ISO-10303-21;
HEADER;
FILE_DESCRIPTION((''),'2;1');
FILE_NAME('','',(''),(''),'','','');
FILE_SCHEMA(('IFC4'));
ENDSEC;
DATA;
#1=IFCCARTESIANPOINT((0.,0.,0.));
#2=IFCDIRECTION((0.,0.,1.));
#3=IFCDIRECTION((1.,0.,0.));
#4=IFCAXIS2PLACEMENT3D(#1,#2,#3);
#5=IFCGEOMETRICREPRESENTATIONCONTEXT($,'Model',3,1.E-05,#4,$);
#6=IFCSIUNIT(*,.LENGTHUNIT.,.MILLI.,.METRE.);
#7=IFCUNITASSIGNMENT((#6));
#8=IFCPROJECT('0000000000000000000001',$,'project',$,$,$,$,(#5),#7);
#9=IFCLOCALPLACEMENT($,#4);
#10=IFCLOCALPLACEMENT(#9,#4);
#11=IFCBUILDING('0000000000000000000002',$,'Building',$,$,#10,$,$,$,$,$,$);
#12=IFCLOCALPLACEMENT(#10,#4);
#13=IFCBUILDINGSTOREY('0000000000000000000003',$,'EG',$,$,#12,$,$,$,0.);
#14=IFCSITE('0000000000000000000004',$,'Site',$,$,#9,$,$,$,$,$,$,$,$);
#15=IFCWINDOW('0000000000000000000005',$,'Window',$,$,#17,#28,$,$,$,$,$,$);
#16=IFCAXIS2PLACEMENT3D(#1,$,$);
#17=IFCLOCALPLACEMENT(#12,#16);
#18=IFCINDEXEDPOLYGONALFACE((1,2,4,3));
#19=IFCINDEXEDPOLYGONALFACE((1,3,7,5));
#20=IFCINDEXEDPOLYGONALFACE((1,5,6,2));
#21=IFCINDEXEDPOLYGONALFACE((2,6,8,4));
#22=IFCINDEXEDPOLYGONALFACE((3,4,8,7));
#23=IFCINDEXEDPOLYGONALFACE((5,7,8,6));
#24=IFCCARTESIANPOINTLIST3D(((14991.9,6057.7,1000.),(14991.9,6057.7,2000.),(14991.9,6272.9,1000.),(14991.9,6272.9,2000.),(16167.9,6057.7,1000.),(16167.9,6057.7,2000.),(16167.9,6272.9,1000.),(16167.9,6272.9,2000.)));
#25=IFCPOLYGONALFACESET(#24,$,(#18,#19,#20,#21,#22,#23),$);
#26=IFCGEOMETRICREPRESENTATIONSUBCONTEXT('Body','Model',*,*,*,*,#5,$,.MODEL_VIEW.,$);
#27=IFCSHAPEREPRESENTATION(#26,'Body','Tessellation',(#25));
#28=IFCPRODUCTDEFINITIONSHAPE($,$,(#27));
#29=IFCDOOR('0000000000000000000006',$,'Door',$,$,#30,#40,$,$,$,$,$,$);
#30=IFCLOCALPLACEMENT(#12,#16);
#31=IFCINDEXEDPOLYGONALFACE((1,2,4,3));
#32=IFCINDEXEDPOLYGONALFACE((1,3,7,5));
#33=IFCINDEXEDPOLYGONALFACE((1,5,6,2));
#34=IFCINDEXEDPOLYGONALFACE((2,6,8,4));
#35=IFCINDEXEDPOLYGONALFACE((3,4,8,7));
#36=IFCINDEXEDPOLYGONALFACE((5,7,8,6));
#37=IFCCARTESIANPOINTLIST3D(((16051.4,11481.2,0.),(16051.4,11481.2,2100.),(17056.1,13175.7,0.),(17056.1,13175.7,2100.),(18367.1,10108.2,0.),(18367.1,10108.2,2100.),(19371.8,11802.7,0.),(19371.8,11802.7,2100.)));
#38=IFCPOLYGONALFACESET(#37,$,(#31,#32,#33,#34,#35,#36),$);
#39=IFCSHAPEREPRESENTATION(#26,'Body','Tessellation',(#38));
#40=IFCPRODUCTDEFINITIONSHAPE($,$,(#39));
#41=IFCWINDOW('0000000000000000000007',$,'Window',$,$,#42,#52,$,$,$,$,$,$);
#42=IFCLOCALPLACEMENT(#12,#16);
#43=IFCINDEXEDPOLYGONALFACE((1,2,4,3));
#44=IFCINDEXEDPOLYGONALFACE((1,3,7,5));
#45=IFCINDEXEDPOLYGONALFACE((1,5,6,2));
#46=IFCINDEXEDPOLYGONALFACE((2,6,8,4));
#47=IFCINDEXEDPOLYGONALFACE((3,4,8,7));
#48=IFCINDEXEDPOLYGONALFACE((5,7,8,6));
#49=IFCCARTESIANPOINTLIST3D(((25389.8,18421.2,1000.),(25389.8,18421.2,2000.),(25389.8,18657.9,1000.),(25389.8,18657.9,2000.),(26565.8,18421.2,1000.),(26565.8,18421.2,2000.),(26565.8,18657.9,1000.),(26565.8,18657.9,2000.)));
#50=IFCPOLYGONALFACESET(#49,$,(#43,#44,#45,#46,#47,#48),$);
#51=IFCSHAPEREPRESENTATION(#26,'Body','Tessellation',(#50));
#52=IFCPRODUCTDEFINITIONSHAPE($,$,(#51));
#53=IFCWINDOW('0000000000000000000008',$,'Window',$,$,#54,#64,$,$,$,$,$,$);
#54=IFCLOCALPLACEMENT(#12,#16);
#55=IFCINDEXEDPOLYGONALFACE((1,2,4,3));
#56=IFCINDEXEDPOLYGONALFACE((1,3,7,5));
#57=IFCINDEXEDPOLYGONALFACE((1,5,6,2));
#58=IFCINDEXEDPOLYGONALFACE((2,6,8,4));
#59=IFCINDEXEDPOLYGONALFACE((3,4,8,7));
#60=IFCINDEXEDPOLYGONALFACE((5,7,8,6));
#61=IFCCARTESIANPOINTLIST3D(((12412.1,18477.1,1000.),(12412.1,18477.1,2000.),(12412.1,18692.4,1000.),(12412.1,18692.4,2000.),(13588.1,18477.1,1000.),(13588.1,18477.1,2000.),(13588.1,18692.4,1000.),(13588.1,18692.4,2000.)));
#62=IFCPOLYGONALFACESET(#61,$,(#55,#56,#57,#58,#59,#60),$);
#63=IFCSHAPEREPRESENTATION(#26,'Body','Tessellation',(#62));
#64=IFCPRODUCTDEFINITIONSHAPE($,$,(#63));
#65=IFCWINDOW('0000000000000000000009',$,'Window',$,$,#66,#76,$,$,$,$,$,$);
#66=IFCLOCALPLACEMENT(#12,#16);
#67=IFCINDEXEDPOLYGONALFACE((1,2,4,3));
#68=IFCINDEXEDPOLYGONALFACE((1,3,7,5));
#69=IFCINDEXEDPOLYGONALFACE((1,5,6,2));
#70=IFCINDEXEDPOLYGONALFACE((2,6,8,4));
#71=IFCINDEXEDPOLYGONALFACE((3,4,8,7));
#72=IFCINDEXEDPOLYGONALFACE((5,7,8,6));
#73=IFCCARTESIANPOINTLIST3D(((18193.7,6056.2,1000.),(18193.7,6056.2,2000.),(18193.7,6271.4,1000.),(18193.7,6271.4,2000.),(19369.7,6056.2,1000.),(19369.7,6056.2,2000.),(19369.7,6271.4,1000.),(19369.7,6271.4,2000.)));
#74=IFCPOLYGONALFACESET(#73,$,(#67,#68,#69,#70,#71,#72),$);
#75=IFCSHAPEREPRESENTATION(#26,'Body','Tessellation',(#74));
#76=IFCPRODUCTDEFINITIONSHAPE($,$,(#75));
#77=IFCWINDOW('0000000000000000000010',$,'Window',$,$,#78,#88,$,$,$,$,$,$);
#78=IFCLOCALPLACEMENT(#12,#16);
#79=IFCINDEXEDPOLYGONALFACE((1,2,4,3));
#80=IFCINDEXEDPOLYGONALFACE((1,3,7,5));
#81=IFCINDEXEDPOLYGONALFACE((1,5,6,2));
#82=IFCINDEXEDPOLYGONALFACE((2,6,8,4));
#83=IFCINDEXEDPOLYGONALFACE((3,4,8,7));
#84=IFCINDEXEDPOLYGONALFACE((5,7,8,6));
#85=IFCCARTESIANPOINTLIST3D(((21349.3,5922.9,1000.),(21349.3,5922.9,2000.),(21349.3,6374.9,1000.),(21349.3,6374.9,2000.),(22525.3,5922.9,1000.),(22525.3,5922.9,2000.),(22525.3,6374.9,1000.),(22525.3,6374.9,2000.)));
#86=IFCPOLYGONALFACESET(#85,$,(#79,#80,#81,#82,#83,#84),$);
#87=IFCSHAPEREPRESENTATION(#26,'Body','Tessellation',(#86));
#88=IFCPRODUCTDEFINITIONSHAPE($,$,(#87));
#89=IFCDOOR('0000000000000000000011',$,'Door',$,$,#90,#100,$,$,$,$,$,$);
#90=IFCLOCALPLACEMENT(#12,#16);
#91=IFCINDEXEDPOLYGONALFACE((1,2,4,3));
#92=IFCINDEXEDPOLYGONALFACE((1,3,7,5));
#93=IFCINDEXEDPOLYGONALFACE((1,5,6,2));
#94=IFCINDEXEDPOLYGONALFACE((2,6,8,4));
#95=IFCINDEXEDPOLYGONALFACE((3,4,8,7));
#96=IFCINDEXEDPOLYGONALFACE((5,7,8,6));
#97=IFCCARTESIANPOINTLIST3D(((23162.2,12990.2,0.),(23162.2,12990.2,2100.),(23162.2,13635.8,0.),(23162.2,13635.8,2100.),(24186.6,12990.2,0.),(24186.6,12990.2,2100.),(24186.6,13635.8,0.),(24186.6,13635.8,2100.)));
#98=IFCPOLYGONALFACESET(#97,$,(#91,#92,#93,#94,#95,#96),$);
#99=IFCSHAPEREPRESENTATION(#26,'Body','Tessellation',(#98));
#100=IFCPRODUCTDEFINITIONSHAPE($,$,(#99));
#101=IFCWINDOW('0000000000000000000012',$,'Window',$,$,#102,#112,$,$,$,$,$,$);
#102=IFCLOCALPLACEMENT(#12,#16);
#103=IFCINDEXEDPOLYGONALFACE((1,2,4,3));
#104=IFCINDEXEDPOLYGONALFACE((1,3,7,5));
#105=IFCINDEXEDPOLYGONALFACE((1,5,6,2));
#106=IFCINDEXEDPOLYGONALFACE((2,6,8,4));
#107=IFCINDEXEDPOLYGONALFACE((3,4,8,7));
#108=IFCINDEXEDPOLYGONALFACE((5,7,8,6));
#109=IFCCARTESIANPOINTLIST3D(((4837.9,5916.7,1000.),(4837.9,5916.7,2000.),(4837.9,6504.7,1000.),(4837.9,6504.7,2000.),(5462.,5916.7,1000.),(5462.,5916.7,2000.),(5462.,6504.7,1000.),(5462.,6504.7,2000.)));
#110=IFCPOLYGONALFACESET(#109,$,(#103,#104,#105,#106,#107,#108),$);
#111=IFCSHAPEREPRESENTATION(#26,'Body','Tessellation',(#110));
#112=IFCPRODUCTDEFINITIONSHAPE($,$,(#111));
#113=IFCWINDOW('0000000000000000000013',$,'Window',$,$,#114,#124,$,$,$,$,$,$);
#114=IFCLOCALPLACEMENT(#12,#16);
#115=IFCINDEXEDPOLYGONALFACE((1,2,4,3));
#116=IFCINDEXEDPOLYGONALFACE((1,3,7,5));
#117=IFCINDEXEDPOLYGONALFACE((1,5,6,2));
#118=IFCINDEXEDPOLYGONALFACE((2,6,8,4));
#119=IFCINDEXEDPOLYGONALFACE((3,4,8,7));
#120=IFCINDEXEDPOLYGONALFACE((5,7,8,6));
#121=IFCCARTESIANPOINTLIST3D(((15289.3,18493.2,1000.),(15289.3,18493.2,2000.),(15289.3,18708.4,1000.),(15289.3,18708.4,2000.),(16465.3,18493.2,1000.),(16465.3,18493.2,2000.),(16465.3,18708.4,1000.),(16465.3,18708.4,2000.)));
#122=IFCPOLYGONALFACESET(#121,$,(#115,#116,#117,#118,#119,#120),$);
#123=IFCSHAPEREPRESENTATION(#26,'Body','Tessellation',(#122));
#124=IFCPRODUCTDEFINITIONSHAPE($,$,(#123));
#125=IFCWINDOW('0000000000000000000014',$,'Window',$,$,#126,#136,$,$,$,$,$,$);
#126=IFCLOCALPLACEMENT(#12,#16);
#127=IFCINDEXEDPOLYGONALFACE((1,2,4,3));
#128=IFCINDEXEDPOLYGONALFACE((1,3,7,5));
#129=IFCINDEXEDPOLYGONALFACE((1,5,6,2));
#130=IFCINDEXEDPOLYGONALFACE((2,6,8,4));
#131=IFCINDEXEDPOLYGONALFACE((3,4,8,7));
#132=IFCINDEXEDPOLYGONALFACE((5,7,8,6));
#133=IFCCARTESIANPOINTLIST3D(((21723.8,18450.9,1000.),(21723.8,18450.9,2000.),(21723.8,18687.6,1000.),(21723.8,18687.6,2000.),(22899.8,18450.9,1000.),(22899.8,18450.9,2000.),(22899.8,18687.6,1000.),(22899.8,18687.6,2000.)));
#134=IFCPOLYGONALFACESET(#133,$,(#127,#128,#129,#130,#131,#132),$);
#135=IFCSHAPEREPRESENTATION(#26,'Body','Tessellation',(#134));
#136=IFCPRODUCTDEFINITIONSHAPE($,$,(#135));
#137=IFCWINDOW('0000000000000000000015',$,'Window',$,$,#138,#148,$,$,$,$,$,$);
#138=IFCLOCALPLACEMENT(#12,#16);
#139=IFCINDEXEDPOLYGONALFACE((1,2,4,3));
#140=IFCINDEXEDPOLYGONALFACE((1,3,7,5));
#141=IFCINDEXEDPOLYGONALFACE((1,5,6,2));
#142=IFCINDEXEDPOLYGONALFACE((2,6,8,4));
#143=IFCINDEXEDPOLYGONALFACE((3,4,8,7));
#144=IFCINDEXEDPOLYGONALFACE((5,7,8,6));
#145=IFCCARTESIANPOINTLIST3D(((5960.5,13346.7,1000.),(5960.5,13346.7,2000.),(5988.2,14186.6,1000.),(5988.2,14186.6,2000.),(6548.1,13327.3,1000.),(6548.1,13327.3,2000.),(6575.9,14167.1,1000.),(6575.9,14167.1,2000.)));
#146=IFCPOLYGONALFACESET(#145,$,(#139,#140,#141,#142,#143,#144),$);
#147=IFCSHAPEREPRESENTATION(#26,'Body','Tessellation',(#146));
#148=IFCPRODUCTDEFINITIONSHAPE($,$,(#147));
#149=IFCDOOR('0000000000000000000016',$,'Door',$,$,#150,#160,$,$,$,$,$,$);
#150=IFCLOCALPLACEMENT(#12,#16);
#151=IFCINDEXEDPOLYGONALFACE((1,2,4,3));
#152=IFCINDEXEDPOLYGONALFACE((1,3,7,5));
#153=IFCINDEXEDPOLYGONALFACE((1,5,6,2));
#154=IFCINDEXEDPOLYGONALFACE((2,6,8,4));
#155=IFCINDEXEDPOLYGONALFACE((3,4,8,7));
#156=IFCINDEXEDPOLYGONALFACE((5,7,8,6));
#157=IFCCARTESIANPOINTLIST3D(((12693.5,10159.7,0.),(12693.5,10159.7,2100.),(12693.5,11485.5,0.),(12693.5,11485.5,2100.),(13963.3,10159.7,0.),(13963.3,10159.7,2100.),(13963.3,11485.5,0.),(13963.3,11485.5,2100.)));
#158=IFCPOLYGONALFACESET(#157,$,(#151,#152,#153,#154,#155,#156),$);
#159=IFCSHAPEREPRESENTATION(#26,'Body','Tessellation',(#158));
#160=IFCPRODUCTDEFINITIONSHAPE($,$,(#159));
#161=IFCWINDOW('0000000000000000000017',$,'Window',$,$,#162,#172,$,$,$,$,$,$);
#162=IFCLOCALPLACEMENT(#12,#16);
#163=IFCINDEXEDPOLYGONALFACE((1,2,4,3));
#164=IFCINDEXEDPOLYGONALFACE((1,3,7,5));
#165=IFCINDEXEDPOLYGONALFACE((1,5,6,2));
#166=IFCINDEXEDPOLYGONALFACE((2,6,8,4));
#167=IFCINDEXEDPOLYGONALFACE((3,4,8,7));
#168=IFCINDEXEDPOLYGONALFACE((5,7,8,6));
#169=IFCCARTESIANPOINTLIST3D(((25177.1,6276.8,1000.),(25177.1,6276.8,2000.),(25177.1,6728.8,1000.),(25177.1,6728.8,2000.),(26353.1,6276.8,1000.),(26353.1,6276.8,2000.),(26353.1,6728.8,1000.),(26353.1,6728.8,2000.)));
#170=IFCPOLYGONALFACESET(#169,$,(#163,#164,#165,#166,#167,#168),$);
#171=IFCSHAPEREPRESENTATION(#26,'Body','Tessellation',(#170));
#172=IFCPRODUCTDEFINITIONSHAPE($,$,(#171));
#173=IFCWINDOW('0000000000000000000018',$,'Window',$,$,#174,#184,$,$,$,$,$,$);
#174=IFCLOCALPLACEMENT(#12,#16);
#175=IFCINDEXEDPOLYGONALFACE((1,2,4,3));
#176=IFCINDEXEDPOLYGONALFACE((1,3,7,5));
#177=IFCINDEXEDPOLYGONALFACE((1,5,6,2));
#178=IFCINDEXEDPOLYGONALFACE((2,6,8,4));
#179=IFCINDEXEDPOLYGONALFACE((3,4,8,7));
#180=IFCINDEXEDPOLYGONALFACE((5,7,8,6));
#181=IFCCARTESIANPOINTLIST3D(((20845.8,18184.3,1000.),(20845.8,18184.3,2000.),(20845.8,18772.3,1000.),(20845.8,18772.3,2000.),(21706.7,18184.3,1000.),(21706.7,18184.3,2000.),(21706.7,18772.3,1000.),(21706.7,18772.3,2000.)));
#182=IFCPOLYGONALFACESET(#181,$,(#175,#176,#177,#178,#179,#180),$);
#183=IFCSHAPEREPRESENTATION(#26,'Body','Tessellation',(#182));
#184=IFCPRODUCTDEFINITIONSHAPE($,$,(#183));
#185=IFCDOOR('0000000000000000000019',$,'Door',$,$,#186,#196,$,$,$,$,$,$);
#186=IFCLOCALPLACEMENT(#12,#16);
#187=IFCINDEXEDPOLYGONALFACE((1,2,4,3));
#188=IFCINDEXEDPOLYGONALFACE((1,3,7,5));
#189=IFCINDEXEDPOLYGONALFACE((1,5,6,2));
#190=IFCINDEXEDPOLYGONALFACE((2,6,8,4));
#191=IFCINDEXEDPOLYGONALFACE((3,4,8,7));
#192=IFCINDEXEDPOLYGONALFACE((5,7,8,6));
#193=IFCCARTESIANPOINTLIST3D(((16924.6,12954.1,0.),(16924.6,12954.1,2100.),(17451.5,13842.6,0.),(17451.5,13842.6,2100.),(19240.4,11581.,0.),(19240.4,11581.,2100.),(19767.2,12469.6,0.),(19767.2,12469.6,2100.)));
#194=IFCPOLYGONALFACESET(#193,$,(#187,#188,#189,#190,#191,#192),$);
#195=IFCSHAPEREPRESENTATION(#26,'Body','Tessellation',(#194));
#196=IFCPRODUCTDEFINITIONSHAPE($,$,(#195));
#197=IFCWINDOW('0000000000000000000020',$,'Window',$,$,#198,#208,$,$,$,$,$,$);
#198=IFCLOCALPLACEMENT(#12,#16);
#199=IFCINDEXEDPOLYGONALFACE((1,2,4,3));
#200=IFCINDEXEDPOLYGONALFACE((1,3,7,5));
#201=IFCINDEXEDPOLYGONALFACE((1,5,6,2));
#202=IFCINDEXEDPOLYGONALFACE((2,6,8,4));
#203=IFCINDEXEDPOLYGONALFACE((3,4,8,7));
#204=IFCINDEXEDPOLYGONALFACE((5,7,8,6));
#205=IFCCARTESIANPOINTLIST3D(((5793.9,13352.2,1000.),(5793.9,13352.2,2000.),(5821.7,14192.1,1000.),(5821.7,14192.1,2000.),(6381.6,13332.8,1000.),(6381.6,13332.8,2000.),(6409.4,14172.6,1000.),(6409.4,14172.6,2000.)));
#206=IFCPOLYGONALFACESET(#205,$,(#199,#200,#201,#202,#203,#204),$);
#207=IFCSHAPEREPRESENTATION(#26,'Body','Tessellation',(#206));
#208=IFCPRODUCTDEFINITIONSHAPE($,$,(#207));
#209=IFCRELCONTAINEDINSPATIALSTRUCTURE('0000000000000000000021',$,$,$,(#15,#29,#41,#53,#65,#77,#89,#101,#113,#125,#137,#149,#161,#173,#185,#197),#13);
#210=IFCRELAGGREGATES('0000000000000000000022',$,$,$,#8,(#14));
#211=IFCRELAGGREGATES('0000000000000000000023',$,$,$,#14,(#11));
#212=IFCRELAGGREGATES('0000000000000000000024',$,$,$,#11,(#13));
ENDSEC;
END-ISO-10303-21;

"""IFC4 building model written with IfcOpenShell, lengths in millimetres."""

from ifc_helpers import new_model, si_unit, frame, origin_with_axes, place, context, subcontext, project, spatial, rectangle, extrude, element, save


model = new_model("IFC4")

# Units and contexts
model_context = context("Model", 3, precision=1e-05, world=origin_with_axes())
body_context = subcontext(model_context, "Body", "Model", "MODEL_VIEW")
ifc_project = project(units=[si_unit("LENGTHUNIT", "METRE", prefix="MILLI")], contexts=[model_context])

# Site, building, storey
site_placement = place(None, origin_with_axes())
site = spatial("IfcSite", under=ifc_project, at=site_placement, Name="Site")
building_placement = place(site_placement, origin_with_axes())
building = spatial("IfcBuilding", under=site, at=building_placement, Name="Building")
storey_placement = place(building_placement, origin_with_axes())
storey = spatial("IfcBuildingStorey", under=building, at=storey_placement, Name="EG", Elevation=0.0)

# Window
window_1_placement = place(storey_placement, origin_with_axes())
element("IfcWindow", 1, at=window_1_placement, inside=storey, Name="Window", context=body_context, shape_type="SweptSolid", body=[
    extrude(rectangle(XDim=1176.0, YDim=215.2), frame((15579.9, 6165.3, 1000.0), z_axis=(0.0, 0.0, 1.0), x_axis=(1.0, 0.0, 0.0)), (0.0, 0.0, 1.0), 1000.0),
])

# Door
door_1_placement = place(storey_placement, origin_with_axes())
element("IfcDoor", 2, at=door_1_placement, inside=storey, Name="Door", context=body_context, shape_type="SweptSolid", body=[
    extrude(rectangle(XDim=1970.0, YDim=2692.2), frame((17711.6, 11641.9, 0.0), z_axis=(0.0, 0.0, 1.0), x_axis=(-0.510011, -0.860168, 0.0)), (0.0, 0.0, 1.0), 2100.0),
])

# Windows
window_2_placement = place(storey_placement, origin_with_axes())
element("IfcWindow", 3, at=window_2_placement, inside=storey, Name="Window", context=body_context, shape_type="SweptSolid", body=[
    extrude(rectangle(XDim=1176.0, YDim=236.7), frame((25977.8, 18539.5, 1000.0), z_axis=(0.0, 0.0, 1.0), x_axis=(1.0, 0.0, 0.0)), (0.0, 0.0, 1.0), 1000.0),
])
window_3_placement = place(storey_placement, origin_with_axes())
element("IfcWindow", 4, at=window_3_placement, inside=storey, Name="Window", context=body_context, shape_type="SweptSolid", body=[
    extrude(rectangle(XDim=1176.0, YDim=215.2), frame((13000.1, 18584.7, 1000.0), z_axis=(0.0, 0.0, 1.0), x_axis=(1.0, 0.0, 0.0)), (0.0, 0.0, 1.0), 1000.0),
])
window_4_placement = place(storey_placement, origin_with_axes())
element("IfcWindow", 5, at=window_4_placement, inside=storey, Name="Window", context=body_context, shape_type="SweptSolid", body=[
    extrude(rectangle(XDim=1176.0, YDim=215.2), frame((18781.7, 6163.8, 1000.0), z_axis=(0.0, 0.0, 1.0), x_axis=(1.0, 0.0, 0.0)), (0.0, 0.0, 1.0), 1000.0),
])
window_5_placement = place(storey_placement, origin_with_axes())
element("IfcWindow", 6, at=window_5_placement, inside=storey, Name="Window", context=body_context, shape_type="SweptSolid", body=[
    extrude(rectangle(XDim=1176.0, YDim=452.0), frame((21937.3, 6148.9, 1000.0), z_axis=(0.0, 0.0, 1.0), x_axis=(1.0, 0.0, 0.0)), (0.0, 0.0, 1.0), 1000.0),
])

# Door
door_2_placement = place(storey_placement, origin_with_axes())
element("IfcDoor", 7, at=door_2_placement, inside=storey, Name="Door", context=body_context, shape_type="SweptSolid", body=[
    extrude(rectangle(XDim=1024.5, YDim=645.7), frame((23674.4, 13313.0, 0.0), z_axis=(0.0, 0.0, 1.0), x_axis=(1.0, 0.0, 0.0)), (0.0, 0.0, 1.0), 2100.0),
])

# Windows
window_6_placement = place(storey_placement, origin_with_axes())
element("IfcWindow", 8, at=window_6_placement, inside=storey, Name="Window", context=body_context, shape_type="SweptSolid", body=[
    extrude(rectangle(XDim=588.0, YDim=624.1), frame((5150.0, 6210.7, 1000.0), z_axis=(0.0, 0.0, 1.0), x_axis=(0.0, 1.0, 0.0)), (0.0, 0.0, 1.0), 1000.0),
])
window_7_placement = place(storey_placement, origin_with_axes())
element("IfcWindow", 9, at=window_7_placement, inside=storey, Name="Window", context=body_context, shape_type="SweptSolid", body=[
    extrude(rectangle(XDim=1176.0, YDim=215.2), frame((15877.3, 18600.8, 1000.0), z_axis=(0.0, 0.0, 1.0), x_axis=(1.0, 0.0, 0.0)), (0.0, 0.0, 1.0), 1000.0),
])
window_8_placement = place(storey_placement, origin_with_axes())
element("IfcWindow", 10, at=window_8_placement, inside=storey, Name="Window", context=body_context, shape_type="SweptSolid", body=[
    extrude(rectangle(XDim=1176.0, YDim=236.7), frame((22311.8, 18569.3, 1000.0), z_axis=(0.0, 0.0, 1.0), x_axis=(1.0, 0.0, 0.0)), (0.0, 0.0, 1.0), 1000.0),
])
window_9_placement = place(storey_placement, origin_with_axes())
element("IfcWindow", 11, at=window_9_placement, inside=storey, Name="Window", context=body_context, shape_type="SweptSolid", body=[
    extrude(rectangle(XDim=588.0, YDim=840.3), frame((6268.2, 13756.9, 1000.0), z_axis=(0.0, 0.0, 1.0), x_axis=(-0.999454, 0.03304, 0.0)), (0.0, 0.0, 1.0), 1000.0),
])

# Door
door_3_placement = place(storey_placement, origin_with_axes())
element("IfcDoor", 12, at=door_3_placement, inside=storey, Name="Door", context=body_context, shape_type="SweptSolid", body=[
    extrude(rectangle(XDim=1325.8, YDim=1269.8), frame((13328.4, 10822.6, 0.0), z_axis=(0.0, 0.0, 1.0), x_axis=(0.0, 1.0, 0.0)), (0.0, 0.0, 1.0), 2100.0),
])

# Windows
window_10_placement = place(storey_placement, origin_with_axes())
element("IfcWindow", 13, at=window_10_placement, inside=storey, Name="Window", context=body_context, shape_type="SweptSolid", body=[
    extrude(rectangle(XDim=1176.0, YDim=452.0), frame((25765.1, 6502.8, 1000.0), z_axis=(0.0, 0.0, 1.0), x_axis=(1.0, 0.0, 0.0)), (0.0, 0.0, 1.0), 1000.0),
])
window_11_placement = place(storey_placement, origin_with_axes())
element("IfcWindow", 14, at=window_11_placement, inside=storey, Name="Window", context=body_context, shape_type="SweptSolid", body=[
    extrude(rectangle(XDim=588.0, YDim=860.9), frame((21276.2, 18478.3, 1000.0), z_axis=(0.0, 0.0, 1.0), x_axis=(0.0, -1.0, 0.0)), (0.0, 0.0, 1.0), 1000.0),
])

# Door
door_4_placement = place(storey_placement, origin_with_axes())
element("IfcDoor", 15, at=door_4_placement, inside=storey, Name="Door", context=body_context, shape_type="SweptSolid", body=[
    extrude(rectangle(XDim=1033.0, YDim=2692.2), frame((18345.9, 12711.8, 0.0), z_axis=(0.0, 0.0, 1.0), x_axis=(-0.510011, -0.860168, 0.0)), (0.0, 0.0, 1.0), 2100.0),
])

# Window
window_12_placement = place(storey_placement, origin_with_axes())
element("IfcWindow", 16, at=window_12_placement, inside=storey, Name="Window", context=body_context, shape_type="SweptSolid", body=[
    extrude(rectangle(XDim=588.0, YDim=840.3), frame((6101.7, 13762.4, 1000.0), z_axis=(0.0, 0.0, 1.0), x_axis=(-0.999454, 0.03304, 0.0)), (0.0, 0.0, 1.0), 1000.0),
])

save(model, "model.ifc")
